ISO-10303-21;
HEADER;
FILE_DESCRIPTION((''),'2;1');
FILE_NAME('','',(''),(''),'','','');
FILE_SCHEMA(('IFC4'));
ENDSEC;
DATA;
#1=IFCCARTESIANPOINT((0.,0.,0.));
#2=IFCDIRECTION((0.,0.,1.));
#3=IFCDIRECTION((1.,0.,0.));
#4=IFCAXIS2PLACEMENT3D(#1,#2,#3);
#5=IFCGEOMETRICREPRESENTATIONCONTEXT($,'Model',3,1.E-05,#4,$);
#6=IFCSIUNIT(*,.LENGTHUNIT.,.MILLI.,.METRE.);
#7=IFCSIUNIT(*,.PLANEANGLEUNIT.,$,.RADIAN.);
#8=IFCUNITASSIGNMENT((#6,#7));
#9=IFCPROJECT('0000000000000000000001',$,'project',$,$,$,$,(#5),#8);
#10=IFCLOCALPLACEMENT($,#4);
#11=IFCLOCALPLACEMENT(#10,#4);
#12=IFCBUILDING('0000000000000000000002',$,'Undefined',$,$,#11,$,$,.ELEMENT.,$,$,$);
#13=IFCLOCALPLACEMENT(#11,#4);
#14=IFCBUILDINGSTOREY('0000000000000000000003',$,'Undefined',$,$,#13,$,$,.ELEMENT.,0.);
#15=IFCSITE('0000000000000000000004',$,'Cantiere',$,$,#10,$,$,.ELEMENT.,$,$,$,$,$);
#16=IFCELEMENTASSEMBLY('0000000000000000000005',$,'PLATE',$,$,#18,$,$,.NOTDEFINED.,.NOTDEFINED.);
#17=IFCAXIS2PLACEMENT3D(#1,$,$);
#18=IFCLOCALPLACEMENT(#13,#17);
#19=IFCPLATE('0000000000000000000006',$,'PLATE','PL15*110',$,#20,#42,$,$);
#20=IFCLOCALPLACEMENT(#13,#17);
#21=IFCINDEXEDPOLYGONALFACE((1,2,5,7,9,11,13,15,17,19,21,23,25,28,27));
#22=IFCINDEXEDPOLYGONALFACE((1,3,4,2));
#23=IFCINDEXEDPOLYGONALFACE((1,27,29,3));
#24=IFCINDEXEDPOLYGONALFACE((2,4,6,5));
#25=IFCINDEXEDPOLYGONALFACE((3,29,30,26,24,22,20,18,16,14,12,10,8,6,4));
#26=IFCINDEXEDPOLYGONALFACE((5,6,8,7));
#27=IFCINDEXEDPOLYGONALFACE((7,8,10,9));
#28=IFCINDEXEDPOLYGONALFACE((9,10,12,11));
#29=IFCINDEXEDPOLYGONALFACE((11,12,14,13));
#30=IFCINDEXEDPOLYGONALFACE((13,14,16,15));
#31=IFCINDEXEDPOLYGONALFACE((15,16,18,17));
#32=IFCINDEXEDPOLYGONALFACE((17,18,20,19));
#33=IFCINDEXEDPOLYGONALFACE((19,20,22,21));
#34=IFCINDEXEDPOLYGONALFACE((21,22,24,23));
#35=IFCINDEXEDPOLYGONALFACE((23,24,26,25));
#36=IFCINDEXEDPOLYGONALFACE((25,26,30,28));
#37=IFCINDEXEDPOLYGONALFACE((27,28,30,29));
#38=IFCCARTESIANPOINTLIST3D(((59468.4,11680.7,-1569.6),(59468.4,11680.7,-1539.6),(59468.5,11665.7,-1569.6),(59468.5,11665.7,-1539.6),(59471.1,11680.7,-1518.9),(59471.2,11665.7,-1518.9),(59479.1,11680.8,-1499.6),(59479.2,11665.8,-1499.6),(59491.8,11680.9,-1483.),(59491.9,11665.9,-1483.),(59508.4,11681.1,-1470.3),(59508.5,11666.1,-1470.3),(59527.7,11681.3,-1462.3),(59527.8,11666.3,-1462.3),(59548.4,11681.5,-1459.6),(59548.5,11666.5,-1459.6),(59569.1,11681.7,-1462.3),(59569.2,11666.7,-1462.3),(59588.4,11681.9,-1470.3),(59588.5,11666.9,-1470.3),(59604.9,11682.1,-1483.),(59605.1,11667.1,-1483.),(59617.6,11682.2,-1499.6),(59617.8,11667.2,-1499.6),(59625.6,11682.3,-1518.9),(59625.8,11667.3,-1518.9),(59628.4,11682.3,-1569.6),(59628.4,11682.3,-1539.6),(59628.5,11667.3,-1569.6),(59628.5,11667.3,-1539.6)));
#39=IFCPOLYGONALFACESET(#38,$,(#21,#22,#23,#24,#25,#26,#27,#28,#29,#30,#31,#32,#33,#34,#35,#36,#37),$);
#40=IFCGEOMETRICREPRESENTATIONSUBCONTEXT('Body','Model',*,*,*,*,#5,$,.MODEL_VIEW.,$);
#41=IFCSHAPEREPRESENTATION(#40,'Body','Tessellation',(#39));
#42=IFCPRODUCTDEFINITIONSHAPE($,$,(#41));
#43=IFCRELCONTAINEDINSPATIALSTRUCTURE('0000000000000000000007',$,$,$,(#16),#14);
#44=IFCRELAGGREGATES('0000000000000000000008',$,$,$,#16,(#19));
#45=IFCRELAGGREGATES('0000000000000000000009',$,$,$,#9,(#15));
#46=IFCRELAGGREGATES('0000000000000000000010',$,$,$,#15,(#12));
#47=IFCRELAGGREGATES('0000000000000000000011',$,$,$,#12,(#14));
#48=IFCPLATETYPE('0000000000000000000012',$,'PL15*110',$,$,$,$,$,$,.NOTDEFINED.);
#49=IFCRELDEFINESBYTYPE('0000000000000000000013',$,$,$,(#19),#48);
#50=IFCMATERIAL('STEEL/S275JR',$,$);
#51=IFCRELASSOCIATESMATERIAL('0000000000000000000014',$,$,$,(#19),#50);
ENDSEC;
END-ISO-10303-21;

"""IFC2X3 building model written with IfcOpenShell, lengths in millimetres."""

from ifc_helpers import new_model, si_unit, frame, frame_2d, origin_with_axes, place, context, subcontext, project, spatial, polyline, circle_curve, parameter, trimmed, segment, composite_curve, outline, extrude, material, type_object, element, aggregate, save


model = new_model("IFC2X3")

# Units and contexts
model_context = context("Model", 3, precision=1e-05, world=origin_with_axes())
body_context = subcontext(model_context, "Body", "Model", "MODEL_VIEW")
ifc_project = project(units=[si_unit("LENGTHUNIT", "METRE", prefix="MILLI"), si_unit("PLANEANGLEUNIT", "RADIAN")], contexts=[model_context])

# Site, building, storey
site_placement = place(None, origin_with_axes())
site = spatial("IfcSite", under=ifc_project, at=site_placement, Name="Cantiere", CompositionType="ELEMENT")
building_placement = place(site_placement, origin_with_axes())
building = spatial("IfcBuilding", under=site, at=building_placement, Name="Undefined", CompositionType="ELEMENT")
storey_placement = place(building_placement, origin_with_axes())
storey = spatial("IfcBuildingStorey", under=building, at=storey_placement, Name="Undefined", CompositionType="ELEMENT", Elevation=0.0)

# Element assembly, plate
ifc_material_1 = material(Name="STEEL/S275JR")
plate_type_1 = type_object("IfcPlateType", Name="PL15*110", PredefinedType="NOTDEFINED")
assembly_1_placement = place(storey_placement, origin_with_axes())
assembly_1 = element("IfcElementAssembly", 1, at=assembly_1_placement, inside=storey, Name="PLATE", AssemblyPlace="NOTDEFINED", PredefinedType="NOTDEFINED")
plate_1_placement = place(assembly_1_placement, frame((59468.4, 11673.2, -1569.6), z_axis=(0.010138, -0.999949, 0.0), x_axis=(0.999949, 0.010139, 0.0)))
plate_1 = element("IfcPlate", 2, at=plate_1_placement, type_object=plate_type_1, material=ifc_material_1, Name="PLATE", Description="PL15*110", context=body_context, shape_type="SweptSolid", body=[
    extrude(outline(composite_curve([segment(polyline([(0.0, 0.0), (160.0, 0.0), (160.0, 30.0)]), True, "CONTINUOUS"), segment(trimmed(circle_curve(frame_2d((80.0, 30.0), x_axis=(1.0, 0.0)), 80.0), [parameter(0.0)], [parameter(1.570796)], True, "PARAMETER"), True, "CONTINUOUS"), segment(trimmed(circle_curve(frame_2d((80.0, 30.0), x_axis=(0.0, 1.0)), 80.0), [parameter(0.0)], [parameter(1.570796)], True, "PARAMETER"), True, "CONTINUOUS"), segment(polyline([(0.0, 30.0), (0.0, 0.0)]), True, "CONTINUOUS")], self_intersect=True)), frame((0.0, 0.0, -7.5), z_axis=(0.0, 0.0, 1.0), x_axis=(1.0, 0.0, 0.0)), (0.0, 0.0, 1.0), 15.0),
])
aggregate(assembly_1, [plate_1])

save(model, "model.ifc")
